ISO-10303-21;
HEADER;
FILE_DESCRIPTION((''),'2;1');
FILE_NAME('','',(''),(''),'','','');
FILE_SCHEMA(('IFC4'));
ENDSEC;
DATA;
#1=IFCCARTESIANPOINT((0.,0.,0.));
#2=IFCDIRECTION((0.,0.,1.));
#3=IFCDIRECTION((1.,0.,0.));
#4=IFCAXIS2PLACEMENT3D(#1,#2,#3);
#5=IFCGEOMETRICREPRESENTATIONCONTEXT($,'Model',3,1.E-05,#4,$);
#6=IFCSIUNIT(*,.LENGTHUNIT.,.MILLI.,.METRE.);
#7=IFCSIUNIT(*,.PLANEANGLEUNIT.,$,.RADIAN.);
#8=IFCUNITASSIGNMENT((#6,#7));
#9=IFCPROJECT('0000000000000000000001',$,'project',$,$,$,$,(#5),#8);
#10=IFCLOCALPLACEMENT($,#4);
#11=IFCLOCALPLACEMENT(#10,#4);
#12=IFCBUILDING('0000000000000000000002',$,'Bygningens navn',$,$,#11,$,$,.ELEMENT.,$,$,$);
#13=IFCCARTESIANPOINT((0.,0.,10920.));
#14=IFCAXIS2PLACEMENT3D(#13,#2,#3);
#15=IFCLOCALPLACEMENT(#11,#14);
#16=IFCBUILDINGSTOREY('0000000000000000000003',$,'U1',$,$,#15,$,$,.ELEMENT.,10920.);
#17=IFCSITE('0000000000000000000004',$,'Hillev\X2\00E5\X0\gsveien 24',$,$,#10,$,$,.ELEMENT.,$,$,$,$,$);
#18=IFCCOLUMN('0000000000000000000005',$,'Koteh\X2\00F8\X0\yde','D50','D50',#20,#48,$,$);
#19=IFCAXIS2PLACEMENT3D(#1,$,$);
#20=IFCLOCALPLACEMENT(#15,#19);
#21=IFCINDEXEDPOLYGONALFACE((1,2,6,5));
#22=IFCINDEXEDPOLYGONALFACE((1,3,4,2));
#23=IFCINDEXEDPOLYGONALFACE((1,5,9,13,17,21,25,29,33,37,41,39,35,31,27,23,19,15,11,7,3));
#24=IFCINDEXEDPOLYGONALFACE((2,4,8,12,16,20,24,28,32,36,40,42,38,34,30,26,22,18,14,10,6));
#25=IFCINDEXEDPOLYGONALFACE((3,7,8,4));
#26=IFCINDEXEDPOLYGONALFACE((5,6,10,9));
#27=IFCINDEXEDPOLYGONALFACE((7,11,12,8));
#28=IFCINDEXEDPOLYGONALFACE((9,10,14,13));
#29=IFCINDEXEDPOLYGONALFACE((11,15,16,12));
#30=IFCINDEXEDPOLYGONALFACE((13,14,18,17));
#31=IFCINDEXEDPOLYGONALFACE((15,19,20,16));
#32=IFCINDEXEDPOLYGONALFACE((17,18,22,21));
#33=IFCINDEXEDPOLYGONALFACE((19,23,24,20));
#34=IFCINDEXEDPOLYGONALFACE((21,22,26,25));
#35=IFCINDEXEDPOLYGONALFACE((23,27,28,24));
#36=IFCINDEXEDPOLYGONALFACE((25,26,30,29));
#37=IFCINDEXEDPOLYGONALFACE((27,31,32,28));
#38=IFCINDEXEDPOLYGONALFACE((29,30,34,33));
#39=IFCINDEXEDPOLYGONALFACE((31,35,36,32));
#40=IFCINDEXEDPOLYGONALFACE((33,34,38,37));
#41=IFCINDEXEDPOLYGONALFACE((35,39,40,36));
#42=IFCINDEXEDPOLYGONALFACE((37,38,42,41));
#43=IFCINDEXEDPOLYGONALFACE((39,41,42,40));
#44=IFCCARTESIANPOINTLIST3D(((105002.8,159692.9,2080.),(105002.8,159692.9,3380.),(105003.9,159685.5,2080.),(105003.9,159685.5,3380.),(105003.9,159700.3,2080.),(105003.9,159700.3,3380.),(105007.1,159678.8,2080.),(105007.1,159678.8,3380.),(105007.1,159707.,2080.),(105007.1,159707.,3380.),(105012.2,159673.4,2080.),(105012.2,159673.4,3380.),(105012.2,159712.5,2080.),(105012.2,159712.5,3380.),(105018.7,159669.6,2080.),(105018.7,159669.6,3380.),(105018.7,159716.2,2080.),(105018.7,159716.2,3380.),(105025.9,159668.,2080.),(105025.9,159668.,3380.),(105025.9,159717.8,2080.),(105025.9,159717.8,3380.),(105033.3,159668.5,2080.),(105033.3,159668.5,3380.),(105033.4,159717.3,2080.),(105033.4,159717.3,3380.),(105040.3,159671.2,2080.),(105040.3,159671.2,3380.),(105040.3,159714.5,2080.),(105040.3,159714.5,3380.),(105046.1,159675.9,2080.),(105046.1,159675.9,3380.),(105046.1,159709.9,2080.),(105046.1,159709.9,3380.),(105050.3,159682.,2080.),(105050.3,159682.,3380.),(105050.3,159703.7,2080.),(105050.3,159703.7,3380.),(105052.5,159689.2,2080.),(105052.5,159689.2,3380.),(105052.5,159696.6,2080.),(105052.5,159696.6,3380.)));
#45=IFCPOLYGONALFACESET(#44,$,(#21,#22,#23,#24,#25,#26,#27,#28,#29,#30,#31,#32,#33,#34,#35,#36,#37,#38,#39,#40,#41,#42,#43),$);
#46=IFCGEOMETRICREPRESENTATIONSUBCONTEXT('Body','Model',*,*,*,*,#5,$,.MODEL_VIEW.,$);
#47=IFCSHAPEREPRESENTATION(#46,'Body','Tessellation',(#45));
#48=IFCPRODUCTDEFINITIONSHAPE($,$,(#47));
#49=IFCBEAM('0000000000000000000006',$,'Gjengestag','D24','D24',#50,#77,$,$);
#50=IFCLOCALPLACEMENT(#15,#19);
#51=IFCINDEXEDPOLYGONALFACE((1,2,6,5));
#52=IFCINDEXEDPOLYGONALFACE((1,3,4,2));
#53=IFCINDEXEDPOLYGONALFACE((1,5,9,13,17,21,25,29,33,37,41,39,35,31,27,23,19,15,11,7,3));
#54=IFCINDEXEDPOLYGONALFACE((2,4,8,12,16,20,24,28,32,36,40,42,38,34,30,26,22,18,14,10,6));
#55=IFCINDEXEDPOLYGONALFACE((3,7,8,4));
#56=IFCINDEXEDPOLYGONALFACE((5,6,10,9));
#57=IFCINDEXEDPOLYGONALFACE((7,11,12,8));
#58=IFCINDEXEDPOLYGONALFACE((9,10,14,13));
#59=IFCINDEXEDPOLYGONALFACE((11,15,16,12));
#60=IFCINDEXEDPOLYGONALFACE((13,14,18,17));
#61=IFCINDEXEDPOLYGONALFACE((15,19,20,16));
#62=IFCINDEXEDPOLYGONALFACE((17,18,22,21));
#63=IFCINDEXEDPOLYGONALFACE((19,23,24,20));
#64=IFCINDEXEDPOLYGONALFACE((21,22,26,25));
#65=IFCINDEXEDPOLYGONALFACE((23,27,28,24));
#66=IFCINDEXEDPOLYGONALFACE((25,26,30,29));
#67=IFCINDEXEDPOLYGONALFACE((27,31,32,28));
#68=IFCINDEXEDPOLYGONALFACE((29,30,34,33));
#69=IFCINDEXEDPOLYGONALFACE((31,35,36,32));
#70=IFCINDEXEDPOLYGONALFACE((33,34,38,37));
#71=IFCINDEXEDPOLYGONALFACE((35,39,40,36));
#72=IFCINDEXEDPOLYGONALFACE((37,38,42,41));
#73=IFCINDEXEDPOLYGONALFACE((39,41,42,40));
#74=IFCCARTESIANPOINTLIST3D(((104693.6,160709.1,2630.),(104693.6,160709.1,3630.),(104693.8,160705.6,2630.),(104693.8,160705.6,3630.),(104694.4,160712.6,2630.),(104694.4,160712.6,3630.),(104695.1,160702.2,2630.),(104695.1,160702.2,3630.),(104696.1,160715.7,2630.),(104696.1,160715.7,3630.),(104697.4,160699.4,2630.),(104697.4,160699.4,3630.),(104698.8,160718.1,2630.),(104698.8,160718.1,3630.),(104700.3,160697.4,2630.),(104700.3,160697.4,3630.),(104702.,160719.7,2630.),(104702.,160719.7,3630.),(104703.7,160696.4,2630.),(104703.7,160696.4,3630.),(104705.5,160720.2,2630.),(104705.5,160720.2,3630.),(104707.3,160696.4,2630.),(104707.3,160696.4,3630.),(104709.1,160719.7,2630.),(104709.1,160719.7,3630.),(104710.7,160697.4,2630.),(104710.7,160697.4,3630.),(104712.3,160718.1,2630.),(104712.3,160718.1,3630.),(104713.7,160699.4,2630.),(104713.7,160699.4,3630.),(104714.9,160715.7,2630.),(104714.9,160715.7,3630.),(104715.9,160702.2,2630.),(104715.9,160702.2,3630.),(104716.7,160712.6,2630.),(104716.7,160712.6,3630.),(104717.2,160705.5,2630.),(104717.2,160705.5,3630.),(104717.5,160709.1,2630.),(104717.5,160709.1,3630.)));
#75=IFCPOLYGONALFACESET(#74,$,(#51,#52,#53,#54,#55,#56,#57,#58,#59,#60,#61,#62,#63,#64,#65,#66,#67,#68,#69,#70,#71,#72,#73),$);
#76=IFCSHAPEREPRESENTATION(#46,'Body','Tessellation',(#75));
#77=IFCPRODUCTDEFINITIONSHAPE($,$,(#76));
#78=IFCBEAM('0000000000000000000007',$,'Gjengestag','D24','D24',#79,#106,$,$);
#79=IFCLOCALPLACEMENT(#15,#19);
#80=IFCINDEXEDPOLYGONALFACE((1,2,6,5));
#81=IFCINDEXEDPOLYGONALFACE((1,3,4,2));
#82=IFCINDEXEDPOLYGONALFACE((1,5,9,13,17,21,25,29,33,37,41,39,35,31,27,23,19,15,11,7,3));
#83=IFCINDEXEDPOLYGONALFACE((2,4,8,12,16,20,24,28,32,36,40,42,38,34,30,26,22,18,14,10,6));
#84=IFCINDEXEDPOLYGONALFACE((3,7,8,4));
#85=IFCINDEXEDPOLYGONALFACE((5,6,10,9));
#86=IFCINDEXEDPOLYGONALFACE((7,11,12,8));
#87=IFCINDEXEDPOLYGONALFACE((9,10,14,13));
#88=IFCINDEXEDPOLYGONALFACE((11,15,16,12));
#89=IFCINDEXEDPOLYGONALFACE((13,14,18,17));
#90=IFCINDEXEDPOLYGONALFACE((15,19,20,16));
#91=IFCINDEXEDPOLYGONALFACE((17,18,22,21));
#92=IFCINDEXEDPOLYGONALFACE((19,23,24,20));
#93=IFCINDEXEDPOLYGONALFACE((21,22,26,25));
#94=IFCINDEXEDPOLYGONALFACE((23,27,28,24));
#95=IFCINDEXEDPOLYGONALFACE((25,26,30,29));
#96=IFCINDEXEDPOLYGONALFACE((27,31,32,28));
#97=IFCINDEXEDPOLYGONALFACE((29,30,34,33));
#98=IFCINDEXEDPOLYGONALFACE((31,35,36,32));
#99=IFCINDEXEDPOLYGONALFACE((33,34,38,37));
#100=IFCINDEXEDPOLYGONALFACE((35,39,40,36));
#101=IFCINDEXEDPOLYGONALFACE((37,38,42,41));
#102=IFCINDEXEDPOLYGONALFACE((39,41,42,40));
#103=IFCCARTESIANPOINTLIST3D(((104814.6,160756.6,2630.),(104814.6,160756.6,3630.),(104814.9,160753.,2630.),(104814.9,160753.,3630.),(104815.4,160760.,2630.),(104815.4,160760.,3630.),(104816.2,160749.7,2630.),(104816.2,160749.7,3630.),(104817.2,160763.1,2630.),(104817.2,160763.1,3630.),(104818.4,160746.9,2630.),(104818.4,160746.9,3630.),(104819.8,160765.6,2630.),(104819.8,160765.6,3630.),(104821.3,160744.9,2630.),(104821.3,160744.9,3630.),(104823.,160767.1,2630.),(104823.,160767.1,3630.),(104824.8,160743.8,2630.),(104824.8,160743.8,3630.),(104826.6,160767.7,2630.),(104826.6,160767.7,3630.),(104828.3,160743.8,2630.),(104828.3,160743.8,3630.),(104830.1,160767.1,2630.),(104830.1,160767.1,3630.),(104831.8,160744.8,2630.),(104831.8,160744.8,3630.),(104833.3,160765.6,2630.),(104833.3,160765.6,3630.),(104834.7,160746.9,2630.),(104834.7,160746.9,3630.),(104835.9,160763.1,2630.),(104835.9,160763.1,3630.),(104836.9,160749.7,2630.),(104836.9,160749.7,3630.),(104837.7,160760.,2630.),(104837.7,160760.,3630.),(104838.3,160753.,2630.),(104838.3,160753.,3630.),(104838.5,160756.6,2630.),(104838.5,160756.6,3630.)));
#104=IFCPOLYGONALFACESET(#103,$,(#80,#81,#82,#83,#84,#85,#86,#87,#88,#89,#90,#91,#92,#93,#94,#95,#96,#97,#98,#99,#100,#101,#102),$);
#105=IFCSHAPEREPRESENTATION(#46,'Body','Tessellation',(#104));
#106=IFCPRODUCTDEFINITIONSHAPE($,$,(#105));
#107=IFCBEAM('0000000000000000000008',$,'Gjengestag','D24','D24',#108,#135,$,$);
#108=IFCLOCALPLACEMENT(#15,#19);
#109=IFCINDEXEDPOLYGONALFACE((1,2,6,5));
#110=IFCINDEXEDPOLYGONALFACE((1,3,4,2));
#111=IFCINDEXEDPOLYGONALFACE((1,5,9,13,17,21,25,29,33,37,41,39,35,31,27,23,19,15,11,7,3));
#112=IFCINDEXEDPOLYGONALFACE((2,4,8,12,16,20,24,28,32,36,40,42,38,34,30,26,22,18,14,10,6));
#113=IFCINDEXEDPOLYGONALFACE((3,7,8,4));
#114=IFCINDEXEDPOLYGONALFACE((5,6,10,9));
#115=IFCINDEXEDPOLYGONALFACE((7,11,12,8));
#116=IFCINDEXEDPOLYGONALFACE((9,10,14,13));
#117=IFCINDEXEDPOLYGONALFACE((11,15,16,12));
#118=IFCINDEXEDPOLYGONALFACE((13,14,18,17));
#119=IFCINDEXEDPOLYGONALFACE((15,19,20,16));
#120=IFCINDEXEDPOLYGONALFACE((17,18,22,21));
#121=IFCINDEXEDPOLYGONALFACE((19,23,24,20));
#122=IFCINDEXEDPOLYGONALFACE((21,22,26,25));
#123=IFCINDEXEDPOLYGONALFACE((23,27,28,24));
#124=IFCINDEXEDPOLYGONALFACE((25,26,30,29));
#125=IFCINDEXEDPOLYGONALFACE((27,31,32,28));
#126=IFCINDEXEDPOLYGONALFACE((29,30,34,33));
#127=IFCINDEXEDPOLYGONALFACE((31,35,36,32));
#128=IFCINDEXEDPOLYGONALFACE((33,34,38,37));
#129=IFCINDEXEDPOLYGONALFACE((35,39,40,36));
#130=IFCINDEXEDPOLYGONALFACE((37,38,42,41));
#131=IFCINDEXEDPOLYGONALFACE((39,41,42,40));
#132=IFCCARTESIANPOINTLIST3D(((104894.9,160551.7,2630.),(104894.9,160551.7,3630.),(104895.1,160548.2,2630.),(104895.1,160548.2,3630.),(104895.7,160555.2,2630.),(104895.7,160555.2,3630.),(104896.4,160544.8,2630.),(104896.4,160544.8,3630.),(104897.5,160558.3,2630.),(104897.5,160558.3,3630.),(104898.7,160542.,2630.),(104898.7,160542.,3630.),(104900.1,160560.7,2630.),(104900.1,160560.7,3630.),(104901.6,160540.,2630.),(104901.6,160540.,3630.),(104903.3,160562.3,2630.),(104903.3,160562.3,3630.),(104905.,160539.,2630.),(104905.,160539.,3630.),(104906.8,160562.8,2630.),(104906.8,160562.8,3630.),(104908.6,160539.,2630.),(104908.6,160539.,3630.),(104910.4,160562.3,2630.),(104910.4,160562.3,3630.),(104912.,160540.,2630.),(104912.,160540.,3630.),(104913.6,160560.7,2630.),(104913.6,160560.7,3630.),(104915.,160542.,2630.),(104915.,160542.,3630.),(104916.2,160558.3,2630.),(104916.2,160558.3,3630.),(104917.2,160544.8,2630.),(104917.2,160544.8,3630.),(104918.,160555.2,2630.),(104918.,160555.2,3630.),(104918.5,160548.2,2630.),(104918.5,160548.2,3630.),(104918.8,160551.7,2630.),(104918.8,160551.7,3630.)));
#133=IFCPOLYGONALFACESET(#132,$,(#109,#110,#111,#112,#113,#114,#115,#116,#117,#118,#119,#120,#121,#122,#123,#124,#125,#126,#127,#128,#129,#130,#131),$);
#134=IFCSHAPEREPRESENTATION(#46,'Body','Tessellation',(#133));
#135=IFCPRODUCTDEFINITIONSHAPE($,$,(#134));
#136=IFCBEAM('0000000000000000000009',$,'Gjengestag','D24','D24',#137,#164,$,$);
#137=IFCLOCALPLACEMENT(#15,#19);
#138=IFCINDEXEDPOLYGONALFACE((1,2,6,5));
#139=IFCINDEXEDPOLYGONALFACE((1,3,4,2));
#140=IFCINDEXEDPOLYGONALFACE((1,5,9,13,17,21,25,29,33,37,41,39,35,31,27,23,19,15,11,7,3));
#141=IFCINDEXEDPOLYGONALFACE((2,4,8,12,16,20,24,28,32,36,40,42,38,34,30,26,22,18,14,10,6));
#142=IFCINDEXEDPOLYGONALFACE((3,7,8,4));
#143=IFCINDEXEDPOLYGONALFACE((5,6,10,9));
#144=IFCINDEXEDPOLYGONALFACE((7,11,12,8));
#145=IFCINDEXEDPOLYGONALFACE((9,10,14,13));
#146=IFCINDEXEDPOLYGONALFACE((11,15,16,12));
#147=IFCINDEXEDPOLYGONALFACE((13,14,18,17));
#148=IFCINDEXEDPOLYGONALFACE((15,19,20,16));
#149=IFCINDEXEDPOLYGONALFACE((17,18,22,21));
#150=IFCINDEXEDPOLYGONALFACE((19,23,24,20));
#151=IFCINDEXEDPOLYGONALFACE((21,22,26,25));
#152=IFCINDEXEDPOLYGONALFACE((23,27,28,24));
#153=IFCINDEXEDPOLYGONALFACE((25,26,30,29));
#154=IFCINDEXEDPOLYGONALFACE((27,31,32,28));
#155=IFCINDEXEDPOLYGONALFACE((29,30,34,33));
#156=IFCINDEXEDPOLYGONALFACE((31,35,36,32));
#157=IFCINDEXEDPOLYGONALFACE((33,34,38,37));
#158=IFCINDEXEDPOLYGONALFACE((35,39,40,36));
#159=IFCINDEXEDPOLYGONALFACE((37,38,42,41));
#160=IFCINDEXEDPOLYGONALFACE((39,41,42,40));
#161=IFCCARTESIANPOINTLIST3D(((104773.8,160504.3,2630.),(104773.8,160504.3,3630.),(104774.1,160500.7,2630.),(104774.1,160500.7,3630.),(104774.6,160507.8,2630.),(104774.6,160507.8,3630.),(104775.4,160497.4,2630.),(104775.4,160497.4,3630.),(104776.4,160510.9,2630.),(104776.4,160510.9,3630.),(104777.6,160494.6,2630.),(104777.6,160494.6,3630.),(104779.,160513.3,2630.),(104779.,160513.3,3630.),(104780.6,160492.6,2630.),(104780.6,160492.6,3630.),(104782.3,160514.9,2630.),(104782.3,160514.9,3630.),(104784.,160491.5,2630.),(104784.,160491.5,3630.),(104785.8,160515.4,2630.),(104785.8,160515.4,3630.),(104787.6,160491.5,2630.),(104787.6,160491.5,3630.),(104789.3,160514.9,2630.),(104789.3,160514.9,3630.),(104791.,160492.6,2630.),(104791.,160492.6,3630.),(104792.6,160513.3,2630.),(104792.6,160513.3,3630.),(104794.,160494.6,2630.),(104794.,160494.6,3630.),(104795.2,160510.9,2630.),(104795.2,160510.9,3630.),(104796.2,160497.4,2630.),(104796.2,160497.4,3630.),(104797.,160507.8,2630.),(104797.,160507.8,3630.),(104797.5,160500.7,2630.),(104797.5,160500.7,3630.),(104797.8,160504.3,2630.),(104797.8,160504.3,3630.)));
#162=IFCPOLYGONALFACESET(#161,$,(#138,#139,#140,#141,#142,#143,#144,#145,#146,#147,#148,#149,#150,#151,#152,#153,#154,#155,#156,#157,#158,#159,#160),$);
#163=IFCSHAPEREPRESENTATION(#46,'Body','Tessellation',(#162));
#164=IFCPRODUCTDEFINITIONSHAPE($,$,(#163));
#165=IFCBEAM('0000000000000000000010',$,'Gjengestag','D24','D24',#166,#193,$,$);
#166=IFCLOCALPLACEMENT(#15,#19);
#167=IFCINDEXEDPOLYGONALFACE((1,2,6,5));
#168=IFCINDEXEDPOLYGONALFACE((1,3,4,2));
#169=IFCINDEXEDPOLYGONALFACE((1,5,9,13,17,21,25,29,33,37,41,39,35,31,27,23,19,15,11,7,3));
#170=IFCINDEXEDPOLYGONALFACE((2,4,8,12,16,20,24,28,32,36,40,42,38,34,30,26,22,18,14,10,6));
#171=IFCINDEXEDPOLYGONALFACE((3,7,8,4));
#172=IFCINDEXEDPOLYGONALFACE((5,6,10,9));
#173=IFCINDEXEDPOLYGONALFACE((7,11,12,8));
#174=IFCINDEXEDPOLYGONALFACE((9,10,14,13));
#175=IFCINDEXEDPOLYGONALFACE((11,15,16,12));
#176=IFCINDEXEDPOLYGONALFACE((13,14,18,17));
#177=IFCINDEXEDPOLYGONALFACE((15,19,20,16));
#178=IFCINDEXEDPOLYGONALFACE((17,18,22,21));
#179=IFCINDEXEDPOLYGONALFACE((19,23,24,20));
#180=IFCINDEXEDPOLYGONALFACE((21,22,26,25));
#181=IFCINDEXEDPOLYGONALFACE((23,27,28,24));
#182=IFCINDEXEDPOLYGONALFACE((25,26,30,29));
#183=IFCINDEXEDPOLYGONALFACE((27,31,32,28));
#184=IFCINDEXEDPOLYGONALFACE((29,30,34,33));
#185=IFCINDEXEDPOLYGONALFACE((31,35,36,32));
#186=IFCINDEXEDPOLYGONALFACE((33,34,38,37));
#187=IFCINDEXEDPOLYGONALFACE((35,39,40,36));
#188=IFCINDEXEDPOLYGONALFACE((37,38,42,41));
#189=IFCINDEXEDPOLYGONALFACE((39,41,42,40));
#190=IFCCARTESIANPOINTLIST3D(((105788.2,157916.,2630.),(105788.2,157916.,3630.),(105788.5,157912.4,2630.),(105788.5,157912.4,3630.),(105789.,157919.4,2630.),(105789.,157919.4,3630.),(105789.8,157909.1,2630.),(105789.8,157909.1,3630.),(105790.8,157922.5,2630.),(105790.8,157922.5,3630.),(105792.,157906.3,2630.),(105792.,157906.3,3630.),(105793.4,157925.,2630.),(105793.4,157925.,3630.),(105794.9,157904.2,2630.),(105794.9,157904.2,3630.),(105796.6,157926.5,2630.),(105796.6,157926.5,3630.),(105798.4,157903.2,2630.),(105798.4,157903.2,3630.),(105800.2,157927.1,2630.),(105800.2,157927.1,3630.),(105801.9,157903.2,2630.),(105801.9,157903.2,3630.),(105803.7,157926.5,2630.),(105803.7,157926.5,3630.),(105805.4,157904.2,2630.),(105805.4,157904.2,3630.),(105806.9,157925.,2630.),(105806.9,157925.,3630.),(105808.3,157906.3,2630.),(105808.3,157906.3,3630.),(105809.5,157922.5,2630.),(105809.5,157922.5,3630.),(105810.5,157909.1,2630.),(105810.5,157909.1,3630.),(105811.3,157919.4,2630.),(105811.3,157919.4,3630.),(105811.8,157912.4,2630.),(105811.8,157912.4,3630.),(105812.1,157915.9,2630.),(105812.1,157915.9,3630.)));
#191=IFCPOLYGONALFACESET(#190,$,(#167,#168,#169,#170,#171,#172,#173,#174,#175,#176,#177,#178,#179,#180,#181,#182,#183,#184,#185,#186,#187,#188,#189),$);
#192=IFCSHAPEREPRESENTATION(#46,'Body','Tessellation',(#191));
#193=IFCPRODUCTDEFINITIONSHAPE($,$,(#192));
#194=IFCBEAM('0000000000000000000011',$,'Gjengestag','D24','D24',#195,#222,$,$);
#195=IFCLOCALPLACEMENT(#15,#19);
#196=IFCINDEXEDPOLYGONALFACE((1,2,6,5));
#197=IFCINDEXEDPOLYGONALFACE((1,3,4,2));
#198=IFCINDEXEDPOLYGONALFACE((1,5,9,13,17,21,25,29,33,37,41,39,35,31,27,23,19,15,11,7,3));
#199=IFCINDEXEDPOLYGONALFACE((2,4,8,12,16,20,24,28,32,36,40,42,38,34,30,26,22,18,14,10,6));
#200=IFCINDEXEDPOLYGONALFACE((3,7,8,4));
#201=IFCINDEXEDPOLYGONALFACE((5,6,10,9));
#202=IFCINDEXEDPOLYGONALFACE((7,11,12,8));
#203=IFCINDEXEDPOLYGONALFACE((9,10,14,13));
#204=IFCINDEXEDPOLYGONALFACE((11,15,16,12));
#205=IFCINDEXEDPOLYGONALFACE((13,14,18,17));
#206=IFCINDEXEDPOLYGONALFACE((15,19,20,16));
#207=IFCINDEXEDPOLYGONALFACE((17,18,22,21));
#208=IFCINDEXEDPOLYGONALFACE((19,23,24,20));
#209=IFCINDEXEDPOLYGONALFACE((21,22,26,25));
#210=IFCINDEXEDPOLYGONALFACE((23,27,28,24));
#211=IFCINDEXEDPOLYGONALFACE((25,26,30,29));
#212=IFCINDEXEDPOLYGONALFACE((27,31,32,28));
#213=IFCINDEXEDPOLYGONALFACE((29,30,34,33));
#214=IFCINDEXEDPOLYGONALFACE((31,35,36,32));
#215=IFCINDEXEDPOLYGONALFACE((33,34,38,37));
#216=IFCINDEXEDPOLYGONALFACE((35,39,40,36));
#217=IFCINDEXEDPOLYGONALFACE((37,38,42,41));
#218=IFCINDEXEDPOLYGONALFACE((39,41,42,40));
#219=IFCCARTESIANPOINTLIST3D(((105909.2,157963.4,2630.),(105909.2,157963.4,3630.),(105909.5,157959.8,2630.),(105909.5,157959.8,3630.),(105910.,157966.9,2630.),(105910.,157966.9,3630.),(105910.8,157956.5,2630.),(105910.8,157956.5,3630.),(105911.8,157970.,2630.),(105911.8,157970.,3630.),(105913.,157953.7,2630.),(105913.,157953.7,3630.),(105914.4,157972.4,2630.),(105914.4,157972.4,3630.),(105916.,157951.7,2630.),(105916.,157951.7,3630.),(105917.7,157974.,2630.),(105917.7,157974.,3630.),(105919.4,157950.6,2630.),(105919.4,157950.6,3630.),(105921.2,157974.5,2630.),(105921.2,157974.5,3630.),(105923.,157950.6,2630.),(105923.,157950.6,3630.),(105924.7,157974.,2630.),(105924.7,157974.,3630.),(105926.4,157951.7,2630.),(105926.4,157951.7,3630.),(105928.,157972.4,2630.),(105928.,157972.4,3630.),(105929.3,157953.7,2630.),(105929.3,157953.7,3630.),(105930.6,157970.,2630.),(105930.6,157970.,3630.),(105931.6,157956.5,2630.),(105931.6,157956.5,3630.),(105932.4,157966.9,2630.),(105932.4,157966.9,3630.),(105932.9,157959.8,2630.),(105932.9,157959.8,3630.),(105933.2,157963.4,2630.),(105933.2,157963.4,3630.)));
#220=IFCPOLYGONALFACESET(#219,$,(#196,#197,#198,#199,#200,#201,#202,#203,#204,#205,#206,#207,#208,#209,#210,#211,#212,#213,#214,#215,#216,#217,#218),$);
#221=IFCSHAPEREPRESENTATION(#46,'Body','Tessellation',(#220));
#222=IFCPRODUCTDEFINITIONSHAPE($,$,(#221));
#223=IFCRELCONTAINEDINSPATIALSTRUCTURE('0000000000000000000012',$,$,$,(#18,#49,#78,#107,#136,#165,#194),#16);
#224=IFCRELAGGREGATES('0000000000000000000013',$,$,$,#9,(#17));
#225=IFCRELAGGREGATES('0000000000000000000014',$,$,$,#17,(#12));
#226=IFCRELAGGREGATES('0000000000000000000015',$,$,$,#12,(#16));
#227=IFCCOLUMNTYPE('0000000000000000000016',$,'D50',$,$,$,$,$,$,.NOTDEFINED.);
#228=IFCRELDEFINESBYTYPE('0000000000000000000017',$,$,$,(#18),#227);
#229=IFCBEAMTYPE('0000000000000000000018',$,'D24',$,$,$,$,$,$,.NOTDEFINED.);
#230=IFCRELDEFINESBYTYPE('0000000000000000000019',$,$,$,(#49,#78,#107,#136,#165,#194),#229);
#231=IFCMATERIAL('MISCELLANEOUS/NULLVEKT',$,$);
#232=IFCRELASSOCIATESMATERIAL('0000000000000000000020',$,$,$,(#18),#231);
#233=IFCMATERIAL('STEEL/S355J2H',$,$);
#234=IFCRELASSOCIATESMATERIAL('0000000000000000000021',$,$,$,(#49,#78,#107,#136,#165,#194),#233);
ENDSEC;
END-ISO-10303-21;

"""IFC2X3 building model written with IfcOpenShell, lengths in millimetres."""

from ifc_helpers import new_model, si_unit, frame, frame_2d, origin_with_axes, place, context, subcontext, project, spatial, circle, extrude, material, type_object, element, save


model = new_model("IFC2X3")

# Units and contexts
model_context = context("Model", 3, precision=1e-05, world=origin_with_axes())
body_context = subcontext(model_context, "Body", "Model", "MODEL_VIEW")
ifc_project = project(units=[si_unit("LENGTHUNIT", "METRE", prefix="MILLI"), si_unit("PLANEANGLEUNIT", "RADIAN")], contexts=[model_context])

# Site, building, storey
site_placement = place(None, origin_with_axes())
site = spatial("IfcSite", under=ifc_project, at=site_placement, Name="Hillevågsveien 24", CompositionType="ELEMENT")
building_placement = place(site_placement, origin_with_axes())
building = spatial("IfcBuilding", under=site, at=building_placement, Name="Bygningens navn", CompositionType="ELEMENT")
storey_placement = place(building_placement, frame((0.0, 0.0, 10920.0), z_axis=(0.0, 0.0, 1.0), x_axis=(1.0, 0.0, 0.0)))
storey = spatial("IfcBuildingStorey", under=building, at=storey_placement, Name="U1", CompositionType="ELEMENT", Elevation=10920.0)

# Column
ifc_material_1 = material(Name="MISCELLANEOUS/NULLVEKT")
column_type = type_object("IfcColumnType", Name="D50", PredefinedType="NOTDEFINED")
column_placement = place(storey_placement, frame((105027.8, 159692.9, 2080.0), z_axis=(0.0, 0.0, 1.0), x_axis=(0.931056, 0.364877, 0.0)))
element("IfcColumn", 1, at=column_placement, inside=storey, type_object=column_type, material=ifc_material_1, Name="Kotehøyde", Description="D50", ObjectType="D50", context=body_context, shape_type="SweptSolid", body=[
    extrude(circle(Radius=25.0, at=frame_2d((0.0, 0.0), x_axis=(1.0, 0.0))), frame((0.0, 0.0, 1300.0), z_axis=(0.0, 0.0, -1.0), x_axis=(0.0, 1.0, 0.0)), (0.0, 0.0, 1.0), 1300.0),
])

# Beams
ifc_material_2 = material(Name="STEEL/S355J2H")
beam_type_1 = type_object("IfcBeamType", Name="D24", PredefinedType="NOTDEFINED")
for number, where, z_axis, x_axis, name in (
    (2, (104705.5, 160708.2, 3630.0), (-0.364877, 0.931056, 0.0), (0.0, 0.0, -1.0), "Gjengestag"),
    (3, (104826.6, 160755.7, 3630.0), (-0.364877, 0.931056, 0.0), (0.0, 0.0, -1.0), "Gjengestag"),
    (4, (104906.8, 160550.8, 3630.0), (-0.364877, 0.931056, 0.0), (0.0, 0.0, -1.0), "Gjengestag"),
    (5, (104785.8, 160503.4, 3630.0), (-0.364877, 0.931056, 0.0), (0.0, 0.0, -1.0), "Gjengestag"),
    (6, (105800.2, 157915.1, 3630.0), (-0.364877, 0.931056, 0.0), (0.0, 0.0, -1.0), "Gjengestag"),
    (7, (105921.2, 157962.5, 3630.0), (-0.364877, 0.931056, 0.0), (0.0, 0.0, -1.0), "Gjengestag"),
):
    element("IfcBeam", number, at=place(storey_placement, frame(where, z_axis=z_axis, x_axis=x_axis)), inside=storey, type_object=beam_type_1, material=ifc_material_2, Name=name, Description="D24", ObjectType="D24", context=body_context, shape_type="SweptSolid", body=[
        extrude(circle(Radius=12.0, at=frame_2d((0.0, 0.0), x_axis=(1.0, 0.0))), frame((1000.0, 0.0, 0.0), z_axis=(-1.0, 0.0, 0.0), x_axis=(0.0, -1.0, 0.0)), (0.0, 0.0, 1.0), 1000.0),
    ])

save(model, "model.ifc")
